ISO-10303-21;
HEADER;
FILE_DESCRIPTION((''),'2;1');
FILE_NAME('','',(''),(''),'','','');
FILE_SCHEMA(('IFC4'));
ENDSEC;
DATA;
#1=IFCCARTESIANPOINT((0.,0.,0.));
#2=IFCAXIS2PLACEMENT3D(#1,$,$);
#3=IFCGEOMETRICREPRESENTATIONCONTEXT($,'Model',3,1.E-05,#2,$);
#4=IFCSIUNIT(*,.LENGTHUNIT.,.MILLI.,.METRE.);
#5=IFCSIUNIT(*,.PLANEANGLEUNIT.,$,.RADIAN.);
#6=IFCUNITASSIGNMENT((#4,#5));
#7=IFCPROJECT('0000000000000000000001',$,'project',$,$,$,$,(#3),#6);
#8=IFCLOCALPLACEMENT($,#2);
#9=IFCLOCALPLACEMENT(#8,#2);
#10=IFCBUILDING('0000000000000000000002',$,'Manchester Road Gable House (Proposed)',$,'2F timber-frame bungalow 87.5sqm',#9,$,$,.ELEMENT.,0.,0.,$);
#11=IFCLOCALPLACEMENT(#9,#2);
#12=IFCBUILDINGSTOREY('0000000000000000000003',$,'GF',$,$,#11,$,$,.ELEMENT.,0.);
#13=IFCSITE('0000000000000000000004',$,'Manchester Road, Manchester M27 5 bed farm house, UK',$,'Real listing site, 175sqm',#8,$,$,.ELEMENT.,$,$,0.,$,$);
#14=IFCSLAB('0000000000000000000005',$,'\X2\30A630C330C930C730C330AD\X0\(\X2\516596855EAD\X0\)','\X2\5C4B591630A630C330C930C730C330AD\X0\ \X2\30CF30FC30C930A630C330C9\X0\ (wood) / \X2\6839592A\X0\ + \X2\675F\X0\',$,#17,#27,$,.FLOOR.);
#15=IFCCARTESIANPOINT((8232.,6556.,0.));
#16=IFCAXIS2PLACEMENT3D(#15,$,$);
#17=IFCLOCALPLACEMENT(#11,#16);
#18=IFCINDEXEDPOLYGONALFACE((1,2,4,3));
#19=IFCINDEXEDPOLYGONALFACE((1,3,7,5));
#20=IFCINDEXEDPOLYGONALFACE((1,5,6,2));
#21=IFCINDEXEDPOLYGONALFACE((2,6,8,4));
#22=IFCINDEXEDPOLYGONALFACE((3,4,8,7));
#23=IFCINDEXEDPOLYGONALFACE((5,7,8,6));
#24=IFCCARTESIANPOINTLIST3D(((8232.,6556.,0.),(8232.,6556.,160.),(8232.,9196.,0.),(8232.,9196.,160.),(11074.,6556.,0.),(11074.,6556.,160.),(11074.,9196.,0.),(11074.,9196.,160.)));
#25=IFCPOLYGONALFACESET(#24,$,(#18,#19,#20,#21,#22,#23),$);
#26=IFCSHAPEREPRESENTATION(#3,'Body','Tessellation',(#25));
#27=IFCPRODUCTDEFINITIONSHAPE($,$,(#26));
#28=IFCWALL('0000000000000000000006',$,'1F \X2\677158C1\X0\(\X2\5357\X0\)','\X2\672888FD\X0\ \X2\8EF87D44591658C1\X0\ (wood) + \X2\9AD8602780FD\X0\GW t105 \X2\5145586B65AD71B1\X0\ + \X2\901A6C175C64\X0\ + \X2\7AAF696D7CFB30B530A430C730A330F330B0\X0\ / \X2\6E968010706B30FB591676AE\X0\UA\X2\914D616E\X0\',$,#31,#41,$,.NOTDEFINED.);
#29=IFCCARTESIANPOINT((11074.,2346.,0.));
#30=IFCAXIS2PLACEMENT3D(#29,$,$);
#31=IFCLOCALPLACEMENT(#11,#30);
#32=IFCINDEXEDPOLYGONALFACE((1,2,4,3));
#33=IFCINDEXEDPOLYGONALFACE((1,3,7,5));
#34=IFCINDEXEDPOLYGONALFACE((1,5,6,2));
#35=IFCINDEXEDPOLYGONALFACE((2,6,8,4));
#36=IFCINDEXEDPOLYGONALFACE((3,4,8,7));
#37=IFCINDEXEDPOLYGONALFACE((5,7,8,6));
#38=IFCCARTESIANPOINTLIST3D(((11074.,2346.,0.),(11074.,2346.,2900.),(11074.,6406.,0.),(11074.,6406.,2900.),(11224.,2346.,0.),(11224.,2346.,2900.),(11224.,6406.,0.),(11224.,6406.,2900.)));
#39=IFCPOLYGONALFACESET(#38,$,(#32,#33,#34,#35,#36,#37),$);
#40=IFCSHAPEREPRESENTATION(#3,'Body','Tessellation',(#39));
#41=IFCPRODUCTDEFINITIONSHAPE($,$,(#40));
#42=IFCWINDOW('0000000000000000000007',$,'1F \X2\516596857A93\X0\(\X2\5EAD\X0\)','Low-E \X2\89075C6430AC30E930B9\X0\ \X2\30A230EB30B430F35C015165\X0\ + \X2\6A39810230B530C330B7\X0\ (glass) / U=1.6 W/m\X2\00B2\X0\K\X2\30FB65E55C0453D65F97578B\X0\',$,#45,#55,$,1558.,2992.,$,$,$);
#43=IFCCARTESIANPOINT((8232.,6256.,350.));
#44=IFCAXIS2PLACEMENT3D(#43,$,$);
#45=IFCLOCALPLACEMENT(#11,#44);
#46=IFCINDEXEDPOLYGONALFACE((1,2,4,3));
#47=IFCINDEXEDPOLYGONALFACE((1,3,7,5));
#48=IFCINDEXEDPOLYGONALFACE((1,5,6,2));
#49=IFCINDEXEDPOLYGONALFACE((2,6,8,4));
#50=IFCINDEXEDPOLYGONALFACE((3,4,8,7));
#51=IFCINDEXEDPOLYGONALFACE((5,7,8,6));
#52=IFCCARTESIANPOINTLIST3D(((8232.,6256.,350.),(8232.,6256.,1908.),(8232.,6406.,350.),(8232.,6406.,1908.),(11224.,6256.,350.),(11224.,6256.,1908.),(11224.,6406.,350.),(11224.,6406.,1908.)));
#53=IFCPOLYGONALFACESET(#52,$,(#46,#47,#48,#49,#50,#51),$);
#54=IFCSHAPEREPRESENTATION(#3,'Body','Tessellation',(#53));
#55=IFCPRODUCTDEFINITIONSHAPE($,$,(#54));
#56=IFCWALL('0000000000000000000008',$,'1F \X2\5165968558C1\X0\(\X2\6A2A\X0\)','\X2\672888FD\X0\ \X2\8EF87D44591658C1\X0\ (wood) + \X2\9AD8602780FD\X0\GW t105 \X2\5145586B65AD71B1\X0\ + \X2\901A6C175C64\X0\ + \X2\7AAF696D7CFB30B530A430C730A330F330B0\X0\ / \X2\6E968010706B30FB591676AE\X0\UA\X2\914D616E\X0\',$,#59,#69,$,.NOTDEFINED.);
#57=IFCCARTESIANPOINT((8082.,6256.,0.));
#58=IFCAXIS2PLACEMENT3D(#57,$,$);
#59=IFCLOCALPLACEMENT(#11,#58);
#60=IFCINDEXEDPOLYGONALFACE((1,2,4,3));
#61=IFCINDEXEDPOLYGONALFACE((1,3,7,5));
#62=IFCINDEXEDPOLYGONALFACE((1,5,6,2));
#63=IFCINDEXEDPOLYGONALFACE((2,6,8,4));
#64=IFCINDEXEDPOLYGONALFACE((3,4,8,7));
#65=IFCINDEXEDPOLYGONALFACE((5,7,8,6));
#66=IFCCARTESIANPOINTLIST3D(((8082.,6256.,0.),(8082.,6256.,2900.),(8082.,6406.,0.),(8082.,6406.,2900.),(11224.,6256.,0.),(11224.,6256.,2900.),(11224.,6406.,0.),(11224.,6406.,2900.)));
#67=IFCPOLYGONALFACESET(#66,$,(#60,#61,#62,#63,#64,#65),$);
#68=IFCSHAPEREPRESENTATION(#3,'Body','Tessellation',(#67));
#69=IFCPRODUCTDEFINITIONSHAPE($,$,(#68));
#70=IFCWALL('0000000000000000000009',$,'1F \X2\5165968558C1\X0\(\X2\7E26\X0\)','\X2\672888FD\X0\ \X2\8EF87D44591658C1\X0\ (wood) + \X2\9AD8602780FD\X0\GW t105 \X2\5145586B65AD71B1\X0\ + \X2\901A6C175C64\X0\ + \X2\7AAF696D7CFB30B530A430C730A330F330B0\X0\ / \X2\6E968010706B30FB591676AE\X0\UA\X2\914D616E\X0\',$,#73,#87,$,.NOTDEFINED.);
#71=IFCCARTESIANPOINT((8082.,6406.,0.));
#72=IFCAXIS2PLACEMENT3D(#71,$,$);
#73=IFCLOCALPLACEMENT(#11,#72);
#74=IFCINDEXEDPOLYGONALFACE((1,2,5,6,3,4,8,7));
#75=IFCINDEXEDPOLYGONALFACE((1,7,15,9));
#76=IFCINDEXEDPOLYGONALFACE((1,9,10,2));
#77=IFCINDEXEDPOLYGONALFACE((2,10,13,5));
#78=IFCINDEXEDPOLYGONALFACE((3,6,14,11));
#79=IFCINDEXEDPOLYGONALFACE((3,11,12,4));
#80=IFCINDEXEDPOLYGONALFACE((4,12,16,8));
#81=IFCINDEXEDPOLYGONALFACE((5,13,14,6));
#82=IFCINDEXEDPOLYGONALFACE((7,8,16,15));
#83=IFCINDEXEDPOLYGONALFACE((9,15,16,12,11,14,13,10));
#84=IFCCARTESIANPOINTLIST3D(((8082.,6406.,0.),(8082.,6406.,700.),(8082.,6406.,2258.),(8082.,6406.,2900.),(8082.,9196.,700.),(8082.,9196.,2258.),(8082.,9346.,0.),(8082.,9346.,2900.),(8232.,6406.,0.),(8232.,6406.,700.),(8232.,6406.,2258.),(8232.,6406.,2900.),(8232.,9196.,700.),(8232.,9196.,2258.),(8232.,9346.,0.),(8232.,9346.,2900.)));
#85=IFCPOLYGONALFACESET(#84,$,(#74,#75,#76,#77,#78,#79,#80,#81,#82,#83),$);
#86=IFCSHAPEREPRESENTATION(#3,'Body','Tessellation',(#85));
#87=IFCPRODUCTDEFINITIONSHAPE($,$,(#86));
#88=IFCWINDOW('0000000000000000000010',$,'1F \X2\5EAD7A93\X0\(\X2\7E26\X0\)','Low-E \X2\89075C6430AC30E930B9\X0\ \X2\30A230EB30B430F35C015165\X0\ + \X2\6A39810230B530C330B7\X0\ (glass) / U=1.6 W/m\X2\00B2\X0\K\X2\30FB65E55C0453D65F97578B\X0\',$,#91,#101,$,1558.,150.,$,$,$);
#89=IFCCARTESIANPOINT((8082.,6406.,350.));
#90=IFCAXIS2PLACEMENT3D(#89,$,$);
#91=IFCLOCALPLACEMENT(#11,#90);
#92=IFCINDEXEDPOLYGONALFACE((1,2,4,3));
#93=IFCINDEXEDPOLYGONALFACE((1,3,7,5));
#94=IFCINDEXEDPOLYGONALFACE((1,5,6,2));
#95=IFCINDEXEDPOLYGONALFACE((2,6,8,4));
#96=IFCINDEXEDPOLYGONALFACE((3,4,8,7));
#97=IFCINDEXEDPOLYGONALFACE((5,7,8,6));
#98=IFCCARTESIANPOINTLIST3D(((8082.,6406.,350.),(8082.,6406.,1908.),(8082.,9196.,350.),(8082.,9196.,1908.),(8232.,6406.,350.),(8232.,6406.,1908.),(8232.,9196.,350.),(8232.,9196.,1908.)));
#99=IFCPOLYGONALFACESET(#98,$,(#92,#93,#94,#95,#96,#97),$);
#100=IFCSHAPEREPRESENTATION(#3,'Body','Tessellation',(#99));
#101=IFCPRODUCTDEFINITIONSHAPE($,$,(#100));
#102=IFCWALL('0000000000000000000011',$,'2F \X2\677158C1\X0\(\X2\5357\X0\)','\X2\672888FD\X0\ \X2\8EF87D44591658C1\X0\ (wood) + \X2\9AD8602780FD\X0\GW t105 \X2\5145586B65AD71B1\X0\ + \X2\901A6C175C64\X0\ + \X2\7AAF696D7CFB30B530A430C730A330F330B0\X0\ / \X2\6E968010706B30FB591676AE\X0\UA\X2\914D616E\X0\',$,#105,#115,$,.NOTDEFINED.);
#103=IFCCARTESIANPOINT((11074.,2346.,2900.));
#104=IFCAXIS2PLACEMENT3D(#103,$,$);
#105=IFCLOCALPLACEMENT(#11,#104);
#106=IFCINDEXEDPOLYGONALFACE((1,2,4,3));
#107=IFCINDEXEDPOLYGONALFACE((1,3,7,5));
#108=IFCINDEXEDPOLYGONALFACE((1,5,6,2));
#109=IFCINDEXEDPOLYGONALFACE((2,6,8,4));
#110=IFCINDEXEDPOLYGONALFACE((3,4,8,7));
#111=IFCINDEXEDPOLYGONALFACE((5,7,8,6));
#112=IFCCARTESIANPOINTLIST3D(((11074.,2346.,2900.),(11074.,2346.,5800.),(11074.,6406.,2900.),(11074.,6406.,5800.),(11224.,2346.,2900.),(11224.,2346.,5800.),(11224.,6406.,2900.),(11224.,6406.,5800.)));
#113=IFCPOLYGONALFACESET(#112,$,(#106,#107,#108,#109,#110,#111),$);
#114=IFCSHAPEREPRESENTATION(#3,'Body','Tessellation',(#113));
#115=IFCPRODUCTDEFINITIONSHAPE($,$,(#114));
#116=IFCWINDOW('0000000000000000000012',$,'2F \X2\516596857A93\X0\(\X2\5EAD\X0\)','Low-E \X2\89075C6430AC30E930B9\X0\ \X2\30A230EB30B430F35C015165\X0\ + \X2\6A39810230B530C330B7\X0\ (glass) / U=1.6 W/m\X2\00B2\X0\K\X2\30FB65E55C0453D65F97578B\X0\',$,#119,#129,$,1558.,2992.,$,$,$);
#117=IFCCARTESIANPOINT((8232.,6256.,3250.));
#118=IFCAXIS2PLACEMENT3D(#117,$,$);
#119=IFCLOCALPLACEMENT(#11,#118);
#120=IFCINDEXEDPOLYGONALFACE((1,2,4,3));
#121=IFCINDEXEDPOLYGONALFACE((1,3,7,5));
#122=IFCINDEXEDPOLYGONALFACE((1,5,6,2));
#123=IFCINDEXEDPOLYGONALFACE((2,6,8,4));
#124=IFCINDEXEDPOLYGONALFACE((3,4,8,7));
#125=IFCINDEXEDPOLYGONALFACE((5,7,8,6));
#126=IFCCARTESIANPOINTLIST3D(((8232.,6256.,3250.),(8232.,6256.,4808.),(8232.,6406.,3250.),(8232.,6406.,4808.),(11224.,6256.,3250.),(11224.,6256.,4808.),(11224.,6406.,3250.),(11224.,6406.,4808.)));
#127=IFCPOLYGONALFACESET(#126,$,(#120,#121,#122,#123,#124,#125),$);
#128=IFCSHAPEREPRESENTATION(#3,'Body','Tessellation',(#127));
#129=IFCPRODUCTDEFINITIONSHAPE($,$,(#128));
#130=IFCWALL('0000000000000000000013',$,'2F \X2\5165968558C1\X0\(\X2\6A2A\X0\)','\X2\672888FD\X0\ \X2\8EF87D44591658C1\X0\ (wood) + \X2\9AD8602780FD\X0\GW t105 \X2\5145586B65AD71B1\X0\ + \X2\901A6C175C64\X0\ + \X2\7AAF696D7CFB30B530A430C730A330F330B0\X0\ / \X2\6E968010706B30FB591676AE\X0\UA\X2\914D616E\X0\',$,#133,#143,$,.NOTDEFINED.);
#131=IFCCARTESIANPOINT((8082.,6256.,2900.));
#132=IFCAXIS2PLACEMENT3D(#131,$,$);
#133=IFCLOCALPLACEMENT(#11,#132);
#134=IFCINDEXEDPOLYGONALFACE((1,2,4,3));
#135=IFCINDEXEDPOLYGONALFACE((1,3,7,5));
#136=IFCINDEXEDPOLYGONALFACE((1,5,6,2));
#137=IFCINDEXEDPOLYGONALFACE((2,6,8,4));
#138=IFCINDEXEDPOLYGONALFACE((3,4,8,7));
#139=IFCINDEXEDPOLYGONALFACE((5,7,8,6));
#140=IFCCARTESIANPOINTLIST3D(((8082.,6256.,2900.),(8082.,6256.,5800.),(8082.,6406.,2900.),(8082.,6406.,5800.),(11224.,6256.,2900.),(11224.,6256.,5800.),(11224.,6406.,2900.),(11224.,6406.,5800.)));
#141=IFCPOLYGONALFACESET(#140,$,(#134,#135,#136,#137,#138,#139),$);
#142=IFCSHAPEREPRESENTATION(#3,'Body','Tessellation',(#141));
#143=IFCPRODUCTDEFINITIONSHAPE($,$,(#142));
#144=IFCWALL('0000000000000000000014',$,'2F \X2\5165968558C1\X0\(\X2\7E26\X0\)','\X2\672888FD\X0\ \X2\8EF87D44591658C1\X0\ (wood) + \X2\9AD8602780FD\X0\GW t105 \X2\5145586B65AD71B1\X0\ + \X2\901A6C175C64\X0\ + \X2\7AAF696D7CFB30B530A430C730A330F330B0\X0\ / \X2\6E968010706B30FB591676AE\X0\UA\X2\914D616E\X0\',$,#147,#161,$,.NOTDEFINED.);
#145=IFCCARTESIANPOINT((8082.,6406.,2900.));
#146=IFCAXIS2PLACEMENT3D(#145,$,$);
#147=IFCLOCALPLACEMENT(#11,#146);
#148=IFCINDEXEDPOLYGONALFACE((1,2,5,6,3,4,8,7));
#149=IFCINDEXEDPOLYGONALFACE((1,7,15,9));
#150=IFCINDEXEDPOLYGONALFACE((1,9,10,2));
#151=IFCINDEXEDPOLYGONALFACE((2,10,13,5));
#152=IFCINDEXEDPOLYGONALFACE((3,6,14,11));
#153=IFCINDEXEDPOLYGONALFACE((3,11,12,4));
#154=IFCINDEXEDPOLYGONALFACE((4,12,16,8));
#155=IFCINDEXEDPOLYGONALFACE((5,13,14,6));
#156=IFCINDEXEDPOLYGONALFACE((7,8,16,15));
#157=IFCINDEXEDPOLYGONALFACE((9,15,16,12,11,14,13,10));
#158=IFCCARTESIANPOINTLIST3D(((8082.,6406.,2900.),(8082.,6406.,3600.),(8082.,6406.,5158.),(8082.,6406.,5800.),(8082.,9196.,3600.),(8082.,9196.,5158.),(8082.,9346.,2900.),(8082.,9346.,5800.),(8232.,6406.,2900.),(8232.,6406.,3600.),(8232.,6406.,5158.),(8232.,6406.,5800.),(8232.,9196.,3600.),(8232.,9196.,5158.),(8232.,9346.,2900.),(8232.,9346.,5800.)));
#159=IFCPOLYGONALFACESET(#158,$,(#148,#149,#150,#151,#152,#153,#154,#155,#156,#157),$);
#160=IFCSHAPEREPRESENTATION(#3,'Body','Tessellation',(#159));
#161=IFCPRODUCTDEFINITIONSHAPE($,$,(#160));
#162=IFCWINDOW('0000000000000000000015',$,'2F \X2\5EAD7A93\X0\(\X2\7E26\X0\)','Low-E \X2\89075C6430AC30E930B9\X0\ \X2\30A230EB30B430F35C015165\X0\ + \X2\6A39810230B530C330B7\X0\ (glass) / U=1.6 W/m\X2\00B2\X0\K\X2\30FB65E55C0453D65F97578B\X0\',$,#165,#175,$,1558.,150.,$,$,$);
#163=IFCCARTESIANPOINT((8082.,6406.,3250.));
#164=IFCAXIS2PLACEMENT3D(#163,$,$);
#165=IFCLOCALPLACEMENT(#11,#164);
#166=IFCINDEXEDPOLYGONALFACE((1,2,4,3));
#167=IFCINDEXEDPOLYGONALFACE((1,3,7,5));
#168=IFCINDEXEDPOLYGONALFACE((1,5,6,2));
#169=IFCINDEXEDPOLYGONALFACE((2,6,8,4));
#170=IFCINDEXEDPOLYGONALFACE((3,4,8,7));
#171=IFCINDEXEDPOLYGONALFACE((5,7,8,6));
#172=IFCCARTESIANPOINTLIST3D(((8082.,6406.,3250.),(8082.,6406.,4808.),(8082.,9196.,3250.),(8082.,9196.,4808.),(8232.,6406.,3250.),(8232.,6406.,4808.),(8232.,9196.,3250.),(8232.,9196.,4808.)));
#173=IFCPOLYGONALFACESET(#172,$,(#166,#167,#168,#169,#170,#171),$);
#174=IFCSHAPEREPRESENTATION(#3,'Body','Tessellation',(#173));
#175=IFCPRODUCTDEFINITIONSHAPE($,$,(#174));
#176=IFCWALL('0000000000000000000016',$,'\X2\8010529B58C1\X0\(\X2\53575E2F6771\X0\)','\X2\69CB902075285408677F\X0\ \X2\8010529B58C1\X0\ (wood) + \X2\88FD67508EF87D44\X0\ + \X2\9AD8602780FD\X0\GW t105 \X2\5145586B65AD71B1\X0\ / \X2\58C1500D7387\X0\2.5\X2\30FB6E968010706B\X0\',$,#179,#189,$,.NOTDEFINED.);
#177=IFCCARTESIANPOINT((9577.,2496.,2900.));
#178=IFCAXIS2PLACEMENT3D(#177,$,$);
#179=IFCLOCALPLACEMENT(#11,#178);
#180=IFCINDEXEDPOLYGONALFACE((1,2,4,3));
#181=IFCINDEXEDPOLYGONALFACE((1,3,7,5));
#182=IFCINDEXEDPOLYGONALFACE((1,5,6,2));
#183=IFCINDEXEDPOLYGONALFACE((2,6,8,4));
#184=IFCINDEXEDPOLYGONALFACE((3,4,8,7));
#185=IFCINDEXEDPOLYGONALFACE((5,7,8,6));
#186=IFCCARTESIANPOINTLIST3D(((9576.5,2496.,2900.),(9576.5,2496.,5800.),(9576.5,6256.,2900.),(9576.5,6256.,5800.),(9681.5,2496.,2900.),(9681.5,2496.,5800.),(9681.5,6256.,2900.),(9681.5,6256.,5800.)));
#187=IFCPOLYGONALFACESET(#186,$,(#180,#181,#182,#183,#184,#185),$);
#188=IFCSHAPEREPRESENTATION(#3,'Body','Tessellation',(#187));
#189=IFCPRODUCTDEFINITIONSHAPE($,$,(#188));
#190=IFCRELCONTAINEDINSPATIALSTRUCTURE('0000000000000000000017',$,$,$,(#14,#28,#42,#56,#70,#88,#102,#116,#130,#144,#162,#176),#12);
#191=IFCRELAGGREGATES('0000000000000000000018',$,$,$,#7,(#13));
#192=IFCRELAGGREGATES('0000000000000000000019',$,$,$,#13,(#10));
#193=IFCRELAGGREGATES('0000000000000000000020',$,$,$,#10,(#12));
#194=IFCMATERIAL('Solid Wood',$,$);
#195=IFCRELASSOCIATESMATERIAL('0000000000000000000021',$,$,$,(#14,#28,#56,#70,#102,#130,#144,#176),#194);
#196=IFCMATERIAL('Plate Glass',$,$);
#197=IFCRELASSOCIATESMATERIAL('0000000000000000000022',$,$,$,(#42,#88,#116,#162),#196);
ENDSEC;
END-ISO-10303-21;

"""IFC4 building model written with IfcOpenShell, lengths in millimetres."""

from ifc_helpers import new_model, si_unit, frame, frame_2d, origin, place, context, project, spatial, rectangle, extrude, material, element, fill, save


model = new_model("IFC4")

# Units and contexts
model_context = context("Model", 3, precision=1e-05, world=origin())
ifc_project = project(units=[si_unit("LENGTHUNIT", "METRE", prefix="MILLI"), si_unit("PLANEANGLEUNIT", "RADIAN")], contexts=[model_context])

# Site, building, storey
site_placement = place(None, origin())
site = spatial("IfcSite", under=ifc_project, at=site_placement, Name="Manchester Road, Manchester M27 5 bed farm house, UK", ObjectType="Real listing site, 175sqm", CompositionType="ELEMENT", RefElevation=0.0)
building_placement = place(site_placement, origin())
building = spatial("IfcBuilding", under=site, at=building_placement, Name="Manchester Road Gable House (Proposed)", ObjectType="2F timber-frame bungalow 87.5sqm", CompositionType="ELEMENT", ElevationOfRefHeight=0.0, ElevationOfTerrain=0.0)
storey_placement = place(building_placement, origin())
storey = spatial("IfcBuildingStorey", under=building, at=storey_placement, Name="GF", CompositionType="ELEMENT", Elevation=0.0)

# Slab
ifc_material_1 = material(Name="Solid Wood")
slab_placement = place(storey_placement, frame((8232.0, 6556.0, 0.0)))
element("IfcSlab", 1, at=slab_placement, inside=storey, material=ifc_material_1, Name="ウッドデッキ(入隅庭)", Description="屋外ウッドデッキ ハードウッド (wood) / 根太 + 束", PredefinedType="FLOOR", context=model_context, shape_type="SweptSolid", body=[
    extrude(rectangle(XDim=2842.0, YDim=2640.0, at=frame_2d((1421.0, 1320.0))), frame((8232.0, 6556.0, 0.0)), (0.0, 0.0, 1.0), 160.0),
])

# Wall, opening, window
wall_1_placement = place(storey_placement, frame((11074.0, 2346.0, 0.0)))
wall_1 = element("IfcWall", 2, at=wall_1_placement, inside=storey, material=ifc_material_1, Name="1F 東壁(南)", Description="木製 軸組外壁 (wood) + 高性能GW t105 充填断熱 + 通気層 + 窯業系サイディング / 準耐火・外皮UA配慮", PredefinedType="NOTDEFINED", context=model_context, shape_type="SweptSolid", body=[
    extrude(rectangle(XDim=150.0, YDim=4060.0, at=frame_2d((75.0, 2030.0))), frame((11074.0, 2346.0, 0.0)), (0.0, 0.0, 1.0), 2900.0),
])
opening_1_placement = place(storey_placement, frame((8232.0, 6256.0, 350.0)))
opening_1 = element("IfcOpeningElement", 3, at=opening_1_placement, cuts=wall_1, PredefinedType="NOTDEFINED", context=model_context, shape_type="SweptSolid", body=[
    extrude(rectangle(XDim=2992.0, YDim=150.0, at=frame_2d((1496.0, 75.0))), frame((8232.0, 6256.0, 350.0)), (0.0, 0.0, 1.0), 1558.0),
])
ifc_material_2 = material(Name="Plate Glass")
window_1_placement = place(storey_placement, frame((8232.0, 6256.0, 350.0)))
window_1 = element("IfcWindow", 4, at=window_1_placement, inside=storey, material=ifc_material_2, Name="1F 入隅窓(庭)", Description="Low-E 複層ガラス アルゴン封入 + 樹脂サッシ (glass) / U=1.6 W/m²K・日射取得型", OverallHeight=1558.0, OverallWidth=2992.0, context=model_context, shape_type="SweptSolid", body=[
    extrude(rectangle(XDim=2992.0, YDim=150.0, at=frame_2d((1496.0, 75.0))), frame((8232.0, 6256.0, 350.0)), (0.0, 0.0, 1.0), 1558.0),
])
fill(opening_1, window_1)

# Wall
wall_2_placement = place(storey_placement, frame((8082.0, 6256.0, 0.0)))
element("IfcWall", 5, at=wall_2_placement, inside=storey, material=ifc_material_1, Name="1F 入隅壁(横)", Description="木製 軸組外壁 (wood) + 高性能GW t105 充填断熱 + 通気層 + 窯業系サイディング / 準耐火・外皮UA配慮", PredefinedType="NOTDEFINED", context=model_context, shape_type="SweptSolid", body=[
    extrude(rectangle(XDim=3142.0, YDim=150.0, at=frame_2d((1571.0, 75.0))), frame((8082.0, 6256.0, 0.0)), (0.0, 0.0, 1.0), 2900.0),
])

# Wall, opening, window
wall_3_placement = place(storey_placement, frame((8082.0, 6406.0, 0.0)))
wall_3 = element("IfcWall", 6, at=wall_3_placement, inside=storey, material=ifc_material_1, Name="1F 入隅壁(縦)", Description="木製 軸組外壁 (wood) + 高性能GW t105 充填断熱 + 通気層 + 窯業系サイディング / 準耐火・外皮UA配慮", PredefinedType="NOTDEFINED", context=model_context, shape_type="SweptSolid", body=[
    extrude(rectangle(XDim=150.0, YDim=2940.0, at=frame_2d((75.0, 1470.0))), frame((8082.0, 6406.0, 0.0)), (0.0, 0.0, 1.0), 2900.0),
])
opening_2_placement = place(storey_placement, frame((8082.0, 6406.0, 350.0)))
opening_2 = element("IfcOpeningElement", 7, at=opening_2_placement, cuts=wall_3, PredefinedType="NOTDEFINED", context=model_context, shape_type="SweptSolid", body=[
    extrude(rectangle(XDim=150.0, YDim=2790.0, at=frame_2d((75.0, 1395.0))), frame((8082.0, 6406.0, 350.0)), (0.0, 0.0, 1.0), 1558.0),
])
window_2_placement = place(storey_placement, frame((8082.0, 6406.0, 350.0)))
window_2 = element("IfcWindow", 8, at=window_2_placement, inside=storey, material=ifc_material_2, Name="1F 庭窓(縦)", Description="Low-E 複層ガラス アルゴン封入 + 樹脂サッシ (glass) / U=1.6 W/m²K・日射取得型", OverallHeight=1558.0, OverallWidth=150.0, context=model_context, shape_type="SweptSolid", body=[
    extrude(rectangle(XDim=150.0, YDim=2790.0, at=frame_2d((75.0, 1395.0))), frame((8082.0, 6406.0, 350.0)), (0.0, 0.0, 1.0), 1558.0),
])
fill(opening_2, window_2)

# Wall, opening, window
wall_4_placement = place(storey_placement, frame((11074.0, 2346.0, 2900.0)))
wall_4 = element("IfcWall", 9, at=wall_4_placement, inside=storey, material=ifc_material_1, Name="2F 東壁(南)", Description="木製 軸組外壁 (wood) + 高性能GW t105 充填断熱 + 通気層 + 窯業系サイディング / 準耐火・外皮UA配慮", PredefinedType="NOTDEFINED", context=model_context, shape_type="SweptSolid", body=[
    extrude(rectangle(XDim=150.0, YDim=4060.0, at=frame_2d((75.0, 2030.0))), frame((11074.0, 2346.0, 2900.0)), (0.0, 0.0, 1.0), 2900.0),
])
opening_3_placement = place(storey_placement, frame((8232.0, 6256.0, 3250.0)))
opening_3 = element("IfcOpeningElement", 10, at=opening_3_placement, cuts=wall_4, PredefinedType="NOTDEFINED", context=model_context, shape_type="SweptSolid", body=[
    extrude(rectangle(XDim=2992.0, YDim=150.0, at=frame_2d((1496.0, 75.0))), frame((8232.0, 6256.0, 3250.0)), (0.0, 0.0, 1.0), 1558.0),
])
window_3_placement = place(storey_placement, frame((8232.0, 6256.0, 3250.0)))
window_3 = element("IfcWindow", 11, at=window_3_placement, inside=storey, material=ifc_material_2, Name="2F 入隅窓(庭)", Description="Low-E 複層ガラス アルゴン封入 + 樹脂サッシ (glass) / U=1.6 W/m²K・日射取得型", OverallHeight=1558.0, OverallWidth=2992.0, context=model_context, shape_type="SweptSolid", body=[
    extrude(rectangle(XDim=2992.0, YDim=150.0, at=frame_2d((1496.0, 75.0))), frame((8232.0, 6256.0, 3250.0)), (0.0, 0.0, 1.0), 1558.0),
])
fill(opening_3, window_3)

# Wall
wall_5_placement = place(storey_placement, frame((8082.0, 6256.0, 2900.0)))
element("IfcWall", 12, at=wall_5_placement, inside=storey, material=ifc_material_1, Name="2F 入隅壁(横)", Description="木製 軸組外壁 (wood) + 高性能GW t105 充填断熱 + 通気層 + 窯業系サイディング / 準耐火・外皮UA配慮", PredefinedType="NOTDEFINED", context=model_context, shape_type="SweptSolid", body=[
    extrude(rectangle(XDim=3142.0, YDim=150.0, at=frame_2d((1571.0, 75.0))), frame((8082.0, 6256.0, 2900.0)), (0.0, 0.0, 1.0), 2900.0),
])

# Wall, opening, window
wall_6_placement = place(storey_placement, frame((8082.0, 6406.0, 2900.0)))
wall_6 = element("IfcWall", 13, at=wall_6_placement, inside=storey, material=ifc_material_1, Name="2F 入隅壁(縦)", Description="木製 軸組外壁 (wood) + 高性能GW t105 充填断熱 + 通気層 + 窯業系サイディング / 準耐火・外皮UA配慮", PredefinedType="NOTDEFINED", context=model_context, shape_type="SweptSolid", body=[
    extrude(rectangle(XDim=150.0, YDim=2940.0, at=frame_2d((75.0, 1470.0))), frame((8082.0, 6406.0, 2900.0)), (0.0, 0.0, 1.0), 2900.0),
])
opening_4_placement = place(storey_placement, frame((8082.0, 6406.0, 3250.0)))
opening_4 = element("IfcOpeningElement", 14, at=opening_4_placement, cuts=wall_6, PredefinedType="NOTDEFINED", context=model_context, shape_type="SweptSolid", body=[
    extrude(rectangle(XDim=150.0, YDim=2790.0, at=frame_2d((75.0, 1395.0))), frame((8082.0, 6406.0, 3250.0)), (0.0, 0.0, 1.0), 1558.0),
])
window_4_placement = place(storey_placement, frame((8082.0, 6406.0, 3250.0)))
window_4 = element("IfcWindow", 15, at=window_4_placement, inside=storey, material=ifc_material_2, Name="2F 庭窓(縦)", Description="Low-E 複層ガラス アルゴン封入 + 樹脂サッシ (glass) / U=1.6 W/m²K・日射取得型", OverallHeight=1558.0, OverallWidth=150.0, context=model_context, shape_type="SweptSolid", body=[
    extrude(rectangle(XDim=150.0, YDim=2790.0, at=frame_2d((75.0, 1395.0))), frame((8082.0, 6406.0, 3250.0)), (0.0, 0.0, 1.0), 1558.0),
])
fill(opening_4, window_4)

# Wall
wall_7_placement = place(storey_placement, frame((9577.0, 2496.0, 2900.0)))
element("IfcWall", 16, at=wall_7_placement, inside=storey, material=ifc_material_1, Name="耐力壁(南帯東)", Description="構造用合板 耐力壁 (wood) + 製材軸組 + 高性能GW t105 充填断熱 / 壁倍率2.5・準耐火", PredefinedType="NOTDEFINED", context=model_context, shape_type="SweptSolid", body=[
    extrude(rectangle(XDim=105.0, YDim=3760.0, at=frame_2d((52.0, 1880.0))), frame((9577.0, 2496.0, 2900.0)), (0.0, 0.0, 1.0), 2900.0),
])

save(model, "model.ifc")
